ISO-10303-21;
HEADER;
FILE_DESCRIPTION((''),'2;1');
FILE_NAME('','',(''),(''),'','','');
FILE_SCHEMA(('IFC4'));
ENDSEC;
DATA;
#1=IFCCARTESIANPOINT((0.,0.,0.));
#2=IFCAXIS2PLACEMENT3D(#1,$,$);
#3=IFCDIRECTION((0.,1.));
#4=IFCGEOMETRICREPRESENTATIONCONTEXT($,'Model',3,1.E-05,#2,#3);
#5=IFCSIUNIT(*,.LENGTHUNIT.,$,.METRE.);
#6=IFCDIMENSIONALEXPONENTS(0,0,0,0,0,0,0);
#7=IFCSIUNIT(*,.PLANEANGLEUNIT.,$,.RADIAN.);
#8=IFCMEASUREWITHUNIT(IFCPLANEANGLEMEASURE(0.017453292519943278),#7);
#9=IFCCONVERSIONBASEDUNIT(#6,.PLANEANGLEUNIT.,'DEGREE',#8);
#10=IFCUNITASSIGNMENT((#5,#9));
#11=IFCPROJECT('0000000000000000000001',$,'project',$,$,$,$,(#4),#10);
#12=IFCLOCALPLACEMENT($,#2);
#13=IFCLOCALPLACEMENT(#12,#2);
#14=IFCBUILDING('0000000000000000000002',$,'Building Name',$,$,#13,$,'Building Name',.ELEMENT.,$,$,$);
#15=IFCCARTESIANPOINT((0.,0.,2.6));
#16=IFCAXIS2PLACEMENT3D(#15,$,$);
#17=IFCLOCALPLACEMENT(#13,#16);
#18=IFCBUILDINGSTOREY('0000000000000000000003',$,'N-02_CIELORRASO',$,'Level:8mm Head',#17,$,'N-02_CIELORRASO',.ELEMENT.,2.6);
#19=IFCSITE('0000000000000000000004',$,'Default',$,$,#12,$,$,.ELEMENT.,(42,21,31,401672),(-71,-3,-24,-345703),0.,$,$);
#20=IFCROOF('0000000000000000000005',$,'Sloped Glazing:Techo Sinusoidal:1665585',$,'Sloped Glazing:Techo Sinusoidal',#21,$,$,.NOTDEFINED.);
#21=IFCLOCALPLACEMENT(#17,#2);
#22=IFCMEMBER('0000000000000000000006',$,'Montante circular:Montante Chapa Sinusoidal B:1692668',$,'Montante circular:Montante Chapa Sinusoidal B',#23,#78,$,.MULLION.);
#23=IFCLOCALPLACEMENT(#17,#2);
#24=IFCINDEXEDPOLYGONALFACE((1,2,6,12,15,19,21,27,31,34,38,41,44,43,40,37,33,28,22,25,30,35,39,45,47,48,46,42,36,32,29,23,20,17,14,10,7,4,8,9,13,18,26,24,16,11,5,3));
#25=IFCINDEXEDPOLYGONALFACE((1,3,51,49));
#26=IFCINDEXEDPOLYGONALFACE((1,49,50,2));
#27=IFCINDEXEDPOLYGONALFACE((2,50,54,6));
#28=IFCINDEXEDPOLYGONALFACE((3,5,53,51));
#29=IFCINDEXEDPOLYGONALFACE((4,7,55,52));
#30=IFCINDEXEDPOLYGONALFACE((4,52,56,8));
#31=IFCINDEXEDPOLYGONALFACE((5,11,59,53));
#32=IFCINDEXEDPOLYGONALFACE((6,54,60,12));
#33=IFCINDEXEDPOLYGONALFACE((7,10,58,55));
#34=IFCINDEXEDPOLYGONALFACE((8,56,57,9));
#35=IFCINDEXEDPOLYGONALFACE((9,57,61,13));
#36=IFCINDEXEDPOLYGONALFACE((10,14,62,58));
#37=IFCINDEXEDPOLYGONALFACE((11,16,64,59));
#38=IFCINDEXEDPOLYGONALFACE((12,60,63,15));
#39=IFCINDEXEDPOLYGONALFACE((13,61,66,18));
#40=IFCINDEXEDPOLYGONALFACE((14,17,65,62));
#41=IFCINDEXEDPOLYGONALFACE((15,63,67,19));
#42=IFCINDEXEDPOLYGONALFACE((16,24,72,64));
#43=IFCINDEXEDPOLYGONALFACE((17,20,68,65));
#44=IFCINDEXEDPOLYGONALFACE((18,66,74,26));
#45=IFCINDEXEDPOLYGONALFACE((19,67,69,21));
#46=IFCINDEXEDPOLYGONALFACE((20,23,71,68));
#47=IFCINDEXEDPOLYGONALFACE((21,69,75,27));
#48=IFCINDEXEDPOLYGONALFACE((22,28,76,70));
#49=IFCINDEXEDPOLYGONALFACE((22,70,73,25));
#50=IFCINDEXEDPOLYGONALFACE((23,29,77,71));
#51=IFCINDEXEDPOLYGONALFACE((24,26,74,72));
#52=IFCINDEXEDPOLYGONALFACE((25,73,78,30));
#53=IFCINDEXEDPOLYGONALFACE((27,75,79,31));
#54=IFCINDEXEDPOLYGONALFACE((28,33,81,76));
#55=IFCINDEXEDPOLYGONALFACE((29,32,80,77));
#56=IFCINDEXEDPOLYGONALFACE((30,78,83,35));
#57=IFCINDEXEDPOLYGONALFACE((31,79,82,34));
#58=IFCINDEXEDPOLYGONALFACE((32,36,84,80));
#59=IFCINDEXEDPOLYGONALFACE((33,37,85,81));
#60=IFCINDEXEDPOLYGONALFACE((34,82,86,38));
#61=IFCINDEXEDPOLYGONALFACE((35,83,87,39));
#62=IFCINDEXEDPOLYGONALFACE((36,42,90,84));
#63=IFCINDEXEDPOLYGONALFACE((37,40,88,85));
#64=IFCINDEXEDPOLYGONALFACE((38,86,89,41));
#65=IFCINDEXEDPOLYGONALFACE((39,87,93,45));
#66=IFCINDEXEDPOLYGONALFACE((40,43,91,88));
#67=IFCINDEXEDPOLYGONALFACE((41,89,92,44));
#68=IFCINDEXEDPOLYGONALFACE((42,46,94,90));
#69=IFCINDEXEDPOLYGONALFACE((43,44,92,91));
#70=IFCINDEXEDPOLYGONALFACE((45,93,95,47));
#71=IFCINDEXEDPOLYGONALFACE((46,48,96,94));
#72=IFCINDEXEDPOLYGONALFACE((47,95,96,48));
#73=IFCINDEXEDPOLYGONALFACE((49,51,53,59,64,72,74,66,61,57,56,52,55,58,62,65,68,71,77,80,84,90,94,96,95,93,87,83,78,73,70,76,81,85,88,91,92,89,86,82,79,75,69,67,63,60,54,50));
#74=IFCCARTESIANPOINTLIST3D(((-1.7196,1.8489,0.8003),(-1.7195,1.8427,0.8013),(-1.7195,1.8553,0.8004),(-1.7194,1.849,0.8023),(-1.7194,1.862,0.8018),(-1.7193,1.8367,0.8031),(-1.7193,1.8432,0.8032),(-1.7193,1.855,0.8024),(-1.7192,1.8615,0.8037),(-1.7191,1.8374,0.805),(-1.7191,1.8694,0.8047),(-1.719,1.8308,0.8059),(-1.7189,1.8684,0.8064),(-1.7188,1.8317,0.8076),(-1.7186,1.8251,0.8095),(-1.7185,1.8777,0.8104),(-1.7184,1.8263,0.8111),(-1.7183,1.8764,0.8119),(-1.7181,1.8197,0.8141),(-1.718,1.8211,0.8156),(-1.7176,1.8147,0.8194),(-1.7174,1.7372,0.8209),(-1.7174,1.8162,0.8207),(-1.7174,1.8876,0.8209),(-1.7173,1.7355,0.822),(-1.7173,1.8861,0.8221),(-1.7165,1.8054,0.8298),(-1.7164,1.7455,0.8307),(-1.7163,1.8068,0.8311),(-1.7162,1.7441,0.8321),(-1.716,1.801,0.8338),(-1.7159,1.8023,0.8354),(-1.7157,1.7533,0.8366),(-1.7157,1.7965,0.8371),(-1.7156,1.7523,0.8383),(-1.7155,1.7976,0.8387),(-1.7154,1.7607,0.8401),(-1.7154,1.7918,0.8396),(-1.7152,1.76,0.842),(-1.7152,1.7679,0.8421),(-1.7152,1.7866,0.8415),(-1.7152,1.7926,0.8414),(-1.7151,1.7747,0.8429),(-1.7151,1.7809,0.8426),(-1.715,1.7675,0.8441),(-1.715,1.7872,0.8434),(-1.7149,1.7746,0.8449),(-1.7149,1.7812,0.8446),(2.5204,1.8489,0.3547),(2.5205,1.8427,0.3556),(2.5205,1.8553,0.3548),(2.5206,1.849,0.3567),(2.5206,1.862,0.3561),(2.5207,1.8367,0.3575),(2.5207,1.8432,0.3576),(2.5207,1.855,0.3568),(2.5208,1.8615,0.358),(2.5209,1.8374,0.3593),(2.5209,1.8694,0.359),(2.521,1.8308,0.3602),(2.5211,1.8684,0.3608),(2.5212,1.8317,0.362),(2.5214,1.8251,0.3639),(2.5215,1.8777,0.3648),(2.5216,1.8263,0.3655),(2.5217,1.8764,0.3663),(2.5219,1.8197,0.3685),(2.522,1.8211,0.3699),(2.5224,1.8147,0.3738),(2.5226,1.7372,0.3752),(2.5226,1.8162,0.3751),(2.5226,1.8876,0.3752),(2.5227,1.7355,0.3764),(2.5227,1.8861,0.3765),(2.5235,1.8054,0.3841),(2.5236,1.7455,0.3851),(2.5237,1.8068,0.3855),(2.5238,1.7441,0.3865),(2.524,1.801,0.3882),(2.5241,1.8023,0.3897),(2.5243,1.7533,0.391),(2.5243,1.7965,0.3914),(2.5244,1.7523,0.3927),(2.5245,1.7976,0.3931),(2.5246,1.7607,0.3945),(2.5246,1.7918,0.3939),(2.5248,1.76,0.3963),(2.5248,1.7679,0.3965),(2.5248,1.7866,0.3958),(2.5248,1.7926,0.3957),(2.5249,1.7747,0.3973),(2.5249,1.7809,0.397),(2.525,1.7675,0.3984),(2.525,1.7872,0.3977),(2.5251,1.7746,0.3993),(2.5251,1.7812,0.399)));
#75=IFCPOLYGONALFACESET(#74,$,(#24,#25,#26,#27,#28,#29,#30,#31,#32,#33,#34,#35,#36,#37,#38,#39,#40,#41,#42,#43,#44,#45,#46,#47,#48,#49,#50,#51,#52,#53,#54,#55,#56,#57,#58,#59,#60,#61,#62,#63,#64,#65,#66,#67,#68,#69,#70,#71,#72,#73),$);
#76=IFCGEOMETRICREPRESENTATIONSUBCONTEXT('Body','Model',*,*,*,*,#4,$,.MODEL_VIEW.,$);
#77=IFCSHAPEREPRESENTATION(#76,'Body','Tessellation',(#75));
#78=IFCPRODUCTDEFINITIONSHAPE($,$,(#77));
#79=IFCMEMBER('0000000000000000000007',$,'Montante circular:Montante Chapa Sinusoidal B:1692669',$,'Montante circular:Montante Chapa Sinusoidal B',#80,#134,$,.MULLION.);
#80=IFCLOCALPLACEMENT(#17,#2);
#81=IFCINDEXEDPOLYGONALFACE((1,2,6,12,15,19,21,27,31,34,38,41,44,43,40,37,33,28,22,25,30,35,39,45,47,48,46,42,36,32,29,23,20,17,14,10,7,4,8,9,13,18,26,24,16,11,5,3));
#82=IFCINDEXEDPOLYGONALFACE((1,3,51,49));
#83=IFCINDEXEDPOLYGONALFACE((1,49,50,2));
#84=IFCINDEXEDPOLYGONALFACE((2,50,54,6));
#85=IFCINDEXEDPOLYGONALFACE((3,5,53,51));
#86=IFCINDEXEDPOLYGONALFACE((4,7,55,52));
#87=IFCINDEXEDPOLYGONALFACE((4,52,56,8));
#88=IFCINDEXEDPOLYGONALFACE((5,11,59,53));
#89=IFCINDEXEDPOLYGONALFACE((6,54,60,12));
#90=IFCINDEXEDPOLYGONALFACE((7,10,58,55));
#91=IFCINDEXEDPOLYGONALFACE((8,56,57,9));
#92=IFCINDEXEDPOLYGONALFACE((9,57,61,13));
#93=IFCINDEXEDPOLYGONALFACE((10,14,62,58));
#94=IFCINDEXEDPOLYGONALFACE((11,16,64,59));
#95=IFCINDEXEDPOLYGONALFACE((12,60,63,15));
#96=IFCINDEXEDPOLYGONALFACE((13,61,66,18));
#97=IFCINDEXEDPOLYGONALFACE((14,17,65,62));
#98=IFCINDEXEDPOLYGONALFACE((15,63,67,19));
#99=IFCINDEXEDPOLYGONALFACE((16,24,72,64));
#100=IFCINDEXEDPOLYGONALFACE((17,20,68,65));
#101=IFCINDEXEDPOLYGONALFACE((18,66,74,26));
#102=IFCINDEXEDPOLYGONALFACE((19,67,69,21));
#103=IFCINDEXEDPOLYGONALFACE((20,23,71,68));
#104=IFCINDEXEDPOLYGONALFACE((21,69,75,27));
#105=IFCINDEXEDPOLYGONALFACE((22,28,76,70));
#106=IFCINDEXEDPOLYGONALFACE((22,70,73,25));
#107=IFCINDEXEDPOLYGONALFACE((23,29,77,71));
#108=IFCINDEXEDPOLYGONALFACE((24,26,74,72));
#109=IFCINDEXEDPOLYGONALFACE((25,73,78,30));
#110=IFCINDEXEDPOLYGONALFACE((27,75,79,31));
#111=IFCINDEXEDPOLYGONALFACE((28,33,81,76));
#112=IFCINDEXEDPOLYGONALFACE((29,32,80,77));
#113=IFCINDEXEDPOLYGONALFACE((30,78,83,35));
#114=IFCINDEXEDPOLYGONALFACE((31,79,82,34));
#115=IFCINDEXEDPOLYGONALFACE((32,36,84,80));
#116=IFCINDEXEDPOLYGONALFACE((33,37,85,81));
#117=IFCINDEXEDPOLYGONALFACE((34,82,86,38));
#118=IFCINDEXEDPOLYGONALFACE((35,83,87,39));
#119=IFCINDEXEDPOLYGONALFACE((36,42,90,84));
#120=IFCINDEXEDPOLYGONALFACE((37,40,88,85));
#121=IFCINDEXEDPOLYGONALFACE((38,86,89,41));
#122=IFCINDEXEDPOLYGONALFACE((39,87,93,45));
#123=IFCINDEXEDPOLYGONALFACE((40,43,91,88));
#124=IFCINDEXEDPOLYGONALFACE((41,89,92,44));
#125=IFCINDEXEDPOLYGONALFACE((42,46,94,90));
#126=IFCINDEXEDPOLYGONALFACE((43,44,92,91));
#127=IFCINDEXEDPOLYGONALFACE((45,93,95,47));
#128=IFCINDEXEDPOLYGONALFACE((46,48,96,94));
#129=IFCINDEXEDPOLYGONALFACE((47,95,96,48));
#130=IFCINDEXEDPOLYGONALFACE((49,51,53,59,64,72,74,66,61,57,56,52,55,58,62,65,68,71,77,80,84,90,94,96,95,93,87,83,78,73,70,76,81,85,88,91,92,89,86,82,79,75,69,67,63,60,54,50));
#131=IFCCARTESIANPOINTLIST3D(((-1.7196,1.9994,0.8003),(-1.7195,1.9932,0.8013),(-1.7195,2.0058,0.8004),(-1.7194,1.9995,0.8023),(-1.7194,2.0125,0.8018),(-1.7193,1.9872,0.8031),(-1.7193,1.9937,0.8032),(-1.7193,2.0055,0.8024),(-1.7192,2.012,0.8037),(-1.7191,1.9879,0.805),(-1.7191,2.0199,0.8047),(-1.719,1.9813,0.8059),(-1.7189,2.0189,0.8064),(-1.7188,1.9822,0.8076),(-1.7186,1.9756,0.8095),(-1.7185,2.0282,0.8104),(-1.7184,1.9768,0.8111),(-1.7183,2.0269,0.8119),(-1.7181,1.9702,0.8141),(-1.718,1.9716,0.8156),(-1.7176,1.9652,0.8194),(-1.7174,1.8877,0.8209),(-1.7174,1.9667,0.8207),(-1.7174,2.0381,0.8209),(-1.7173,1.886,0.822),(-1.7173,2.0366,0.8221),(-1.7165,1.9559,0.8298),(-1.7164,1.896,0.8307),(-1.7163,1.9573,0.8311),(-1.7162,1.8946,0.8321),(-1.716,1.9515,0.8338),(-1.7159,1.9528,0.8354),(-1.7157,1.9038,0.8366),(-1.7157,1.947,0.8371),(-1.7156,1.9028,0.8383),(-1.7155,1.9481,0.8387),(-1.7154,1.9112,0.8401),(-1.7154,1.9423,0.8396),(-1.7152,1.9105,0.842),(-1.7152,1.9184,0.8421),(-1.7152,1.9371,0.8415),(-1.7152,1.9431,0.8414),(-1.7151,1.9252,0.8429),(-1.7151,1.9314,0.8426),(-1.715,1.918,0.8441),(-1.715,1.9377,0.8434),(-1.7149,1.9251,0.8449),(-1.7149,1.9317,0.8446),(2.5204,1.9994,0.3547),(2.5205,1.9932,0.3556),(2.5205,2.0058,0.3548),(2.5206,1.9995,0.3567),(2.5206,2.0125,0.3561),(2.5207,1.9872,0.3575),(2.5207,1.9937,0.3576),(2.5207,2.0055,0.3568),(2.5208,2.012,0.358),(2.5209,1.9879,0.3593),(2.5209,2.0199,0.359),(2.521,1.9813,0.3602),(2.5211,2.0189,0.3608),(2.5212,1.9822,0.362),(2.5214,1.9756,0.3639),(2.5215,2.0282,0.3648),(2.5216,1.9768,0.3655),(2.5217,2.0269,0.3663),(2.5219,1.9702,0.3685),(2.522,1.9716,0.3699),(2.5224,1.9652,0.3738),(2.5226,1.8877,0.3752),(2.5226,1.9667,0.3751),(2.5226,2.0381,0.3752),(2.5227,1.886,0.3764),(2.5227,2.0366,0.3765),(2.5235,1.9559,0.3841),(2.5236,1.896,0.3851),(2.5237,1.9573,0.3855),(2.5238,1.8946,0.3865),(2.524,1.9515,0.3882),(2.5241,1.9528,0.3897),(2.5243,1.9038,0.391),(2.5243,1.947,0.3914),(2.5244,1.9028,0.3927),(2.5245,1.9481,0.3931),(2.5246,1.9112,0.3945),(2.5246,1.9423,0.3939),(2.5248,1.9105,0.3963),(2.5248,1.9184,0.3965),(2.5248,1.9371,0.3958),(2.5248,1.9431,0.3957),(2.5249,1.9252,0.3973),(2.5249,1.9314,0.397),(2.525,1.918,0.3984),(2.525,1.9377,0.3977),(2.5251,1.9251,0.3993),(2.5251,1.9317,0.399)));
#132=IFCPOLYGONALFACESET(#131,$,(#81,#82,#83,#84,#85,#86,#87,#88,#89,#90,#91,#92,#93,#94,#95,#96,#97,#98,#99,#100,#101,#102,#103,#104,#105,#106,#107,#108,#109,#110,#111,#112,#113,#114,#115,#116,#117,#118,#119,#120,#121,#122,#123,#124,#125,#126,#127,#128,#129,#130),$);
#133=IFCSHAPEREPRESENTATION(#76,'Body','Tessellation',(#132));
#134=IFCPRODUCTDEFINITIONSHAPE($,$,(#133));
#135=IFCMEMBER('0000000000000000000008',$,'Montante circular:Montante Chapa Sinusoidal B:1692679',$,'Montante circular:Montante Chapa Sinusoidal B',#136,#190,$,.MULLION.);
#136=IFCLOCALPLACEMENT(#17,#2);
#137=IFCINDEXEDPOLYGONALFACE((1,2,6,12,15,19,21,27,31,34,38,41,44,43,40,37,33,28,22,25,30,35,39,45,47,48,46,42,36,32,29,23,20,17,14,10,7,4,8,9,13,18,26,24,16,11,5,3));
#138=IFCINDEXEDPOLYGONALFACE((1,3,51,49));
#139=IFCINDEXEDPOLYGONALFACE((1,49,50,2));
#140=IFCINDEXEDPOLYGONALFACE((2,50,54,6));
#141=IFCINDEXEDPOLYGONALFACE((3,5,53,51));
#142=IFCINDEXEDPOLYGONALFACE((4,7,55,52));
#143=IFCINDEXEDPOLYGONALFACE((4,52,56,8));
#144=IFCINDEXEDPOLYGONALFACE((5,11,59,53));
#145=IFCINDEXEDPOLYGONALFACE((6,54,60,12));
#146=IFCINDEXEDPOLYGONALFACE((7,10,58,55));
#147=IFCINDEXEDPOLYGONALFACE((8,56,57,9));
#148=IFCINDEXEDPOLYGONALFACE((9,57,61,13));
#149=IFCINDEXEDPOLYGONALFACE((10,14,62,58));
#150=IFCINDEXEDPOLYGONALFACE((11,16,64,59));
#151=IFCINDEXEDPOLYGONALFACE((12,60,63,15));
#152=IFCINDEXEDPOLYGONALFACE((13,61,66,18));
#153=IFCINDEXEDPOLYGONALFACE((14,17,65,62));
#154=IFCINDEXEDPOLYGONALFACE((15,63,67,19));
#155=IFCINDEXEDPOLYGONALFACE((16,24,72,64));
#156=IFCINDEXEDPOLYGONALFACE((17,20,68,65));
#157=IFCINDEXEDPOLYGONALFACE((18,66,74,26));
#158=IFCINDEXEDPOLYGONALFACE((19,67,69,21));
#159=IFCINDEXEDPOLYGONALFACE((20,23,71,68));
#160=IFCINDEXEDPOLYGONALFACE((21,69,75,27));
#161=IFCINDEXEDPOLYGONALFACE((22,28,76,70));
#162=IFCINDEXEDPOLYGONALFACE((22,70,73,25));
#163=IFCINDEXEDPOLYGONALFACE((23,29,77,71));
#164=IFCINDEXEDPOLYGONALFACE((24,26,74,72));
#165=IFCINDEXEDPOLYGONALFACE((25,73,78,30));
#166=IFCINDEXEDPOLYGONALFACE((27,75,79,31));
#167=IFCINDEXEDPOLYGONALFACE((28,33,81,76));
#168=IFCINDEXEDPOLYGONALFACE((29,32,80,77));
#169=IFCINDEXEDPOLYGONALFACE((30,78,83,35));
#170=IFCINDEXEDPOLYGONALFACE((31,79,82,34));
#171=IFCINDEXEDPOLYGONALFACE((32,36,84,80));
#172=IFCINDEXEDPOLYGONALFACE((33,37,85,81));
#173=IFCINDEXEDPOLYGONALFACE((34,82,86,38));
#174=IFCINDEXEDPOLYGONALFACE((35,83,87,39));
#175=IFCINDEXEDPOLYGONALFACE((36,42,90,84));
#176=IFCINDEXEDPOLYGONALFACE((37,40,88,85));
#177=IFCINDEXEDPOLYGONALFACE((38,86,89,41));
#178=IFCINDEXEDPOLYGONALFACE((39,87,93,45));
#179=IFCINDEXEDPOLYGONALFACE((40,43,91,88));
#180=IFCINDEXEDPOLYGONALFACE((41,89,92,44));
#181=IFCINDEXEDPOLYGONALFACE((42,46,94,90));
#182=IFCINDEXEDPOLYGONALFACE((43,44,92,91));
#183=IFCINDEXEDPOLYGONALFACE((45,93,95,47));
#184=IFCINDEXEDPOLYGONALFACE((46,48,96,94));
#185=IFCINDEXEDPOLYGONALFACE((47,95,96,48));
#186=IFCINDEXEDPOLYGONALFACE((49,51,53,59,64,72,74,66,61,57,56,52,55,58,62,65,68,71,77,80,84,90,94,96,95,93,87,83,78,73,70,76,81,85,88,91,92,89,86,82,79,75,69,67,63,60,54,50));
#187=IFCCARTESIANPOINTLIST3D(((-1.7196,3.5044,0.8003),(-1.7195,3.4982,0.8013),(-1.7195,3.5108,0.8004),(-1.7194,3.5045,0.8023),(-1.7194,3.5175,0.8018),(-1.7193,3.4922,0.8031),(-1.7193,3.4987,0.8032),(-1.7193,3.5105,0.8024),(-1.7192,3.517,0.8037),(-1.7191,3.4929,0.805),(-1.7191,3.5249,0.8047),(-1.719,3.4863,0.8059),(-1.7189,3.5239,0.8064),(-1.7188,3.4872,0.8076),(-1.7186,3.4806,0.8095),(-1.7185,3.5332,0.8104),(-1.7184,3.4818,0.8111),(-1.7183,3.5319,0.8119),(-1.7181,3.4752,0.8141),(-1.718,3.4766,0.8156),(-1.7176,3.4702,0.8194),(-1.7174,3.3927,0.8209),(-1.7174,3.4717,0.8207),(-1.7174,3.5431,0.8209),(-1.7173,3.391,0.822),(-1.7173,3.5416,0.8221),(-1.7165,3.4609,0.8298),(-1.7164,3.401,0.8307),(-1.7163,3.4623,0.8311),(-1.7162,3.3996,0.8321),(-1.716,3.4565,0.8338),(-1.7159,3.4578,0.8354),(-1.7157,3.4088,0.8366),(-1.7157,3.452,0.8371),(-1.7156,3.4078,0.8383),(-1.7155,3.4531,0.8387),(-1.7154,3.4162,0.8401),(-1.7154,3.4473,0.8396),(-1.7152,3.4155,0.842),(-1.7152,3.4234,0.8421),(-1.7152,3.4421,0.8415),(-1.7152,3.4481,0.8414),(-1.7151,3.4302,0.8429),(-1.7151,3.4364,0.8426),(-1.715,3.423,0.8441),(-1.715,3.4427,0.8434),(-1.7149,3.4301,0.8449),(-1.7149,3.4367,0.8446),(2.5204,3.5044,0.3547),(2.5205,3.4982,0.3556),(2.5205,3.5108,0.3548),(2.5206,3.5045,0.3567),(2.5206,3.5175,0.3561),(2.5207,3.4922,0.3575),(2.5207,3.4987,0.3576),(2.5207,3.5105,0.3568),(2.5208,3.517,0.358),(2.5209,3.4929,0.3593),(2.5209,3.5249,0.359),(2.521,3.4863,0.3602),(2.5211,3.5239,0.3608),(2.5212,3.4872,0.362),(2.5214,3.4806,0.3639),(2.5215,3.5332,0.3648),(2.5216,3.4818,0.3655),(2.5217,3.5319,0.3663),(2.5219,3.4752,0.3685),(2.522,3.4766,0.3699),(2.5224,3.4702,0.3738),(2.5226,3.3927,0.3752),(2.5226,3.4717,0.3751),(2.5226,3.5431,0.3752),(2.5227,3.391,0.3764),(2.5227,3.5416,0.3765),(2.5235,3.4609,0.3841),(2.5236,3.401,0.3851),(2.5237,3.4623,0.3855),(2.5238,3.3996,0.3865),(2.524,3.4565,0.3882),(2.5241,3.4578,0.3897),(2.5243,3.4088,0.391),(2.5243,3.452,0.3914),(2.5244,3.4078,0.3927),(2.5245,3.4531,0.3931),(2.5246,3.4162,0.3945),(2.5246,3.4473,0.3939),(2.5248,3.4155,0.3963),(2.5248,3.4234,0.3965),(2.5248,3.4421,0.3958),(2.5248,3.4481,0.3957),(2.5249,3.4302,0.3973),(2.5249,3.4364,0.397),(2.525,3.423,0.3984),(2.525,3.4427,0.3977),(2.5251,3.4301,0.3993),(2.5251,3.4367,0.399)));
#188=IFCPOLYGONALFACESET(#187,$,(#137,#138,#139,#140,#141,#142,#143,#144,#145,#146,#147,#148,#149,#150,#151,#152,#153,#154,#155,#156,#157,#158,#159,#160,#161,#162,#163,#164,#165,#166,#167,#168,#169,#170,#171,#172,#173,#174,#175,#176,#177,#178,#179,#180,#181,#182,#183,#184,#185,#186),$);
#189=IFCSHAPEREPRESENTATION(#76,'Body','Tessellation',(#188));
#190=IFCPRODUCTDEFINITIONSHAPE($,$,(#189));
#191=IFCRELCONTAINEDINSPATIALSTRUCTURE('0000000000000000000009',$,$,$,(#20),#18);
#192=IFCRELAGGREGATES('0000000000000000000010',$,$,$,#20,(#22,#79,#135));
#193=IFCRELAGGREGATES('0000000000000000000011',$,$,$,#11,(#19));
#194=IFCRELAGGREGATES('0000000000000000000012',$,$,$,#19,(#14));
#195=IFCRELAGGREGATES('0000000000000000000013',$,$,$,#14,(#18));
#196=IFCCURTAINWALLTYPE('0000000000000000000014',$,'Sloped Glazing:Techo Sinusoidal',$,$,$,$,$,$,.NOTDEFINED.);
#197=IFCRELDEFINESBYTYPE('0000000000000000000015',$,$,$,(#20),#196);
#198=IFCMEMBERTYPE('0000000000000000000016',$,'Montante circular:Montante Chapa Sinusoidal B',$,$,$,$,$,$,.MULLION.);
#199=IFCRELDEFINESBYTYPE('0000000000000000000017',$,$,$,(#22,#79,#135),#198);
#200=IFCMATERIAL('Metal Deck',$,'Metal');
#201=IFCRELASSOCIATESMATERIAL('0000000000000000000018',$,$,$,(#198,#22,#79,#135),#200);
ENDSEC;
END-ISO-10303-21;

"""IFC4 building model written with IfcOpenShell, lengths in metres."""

from ifc_helpers import new_model, entity, si_unit, converted_unit, direction, frame, origin, place, context, subcontext, project, spatial, indexed_curve, outline, extrude, source, transform, mapped, material, type_object, type_shapes, element, aggregate, save


model = new_model("IFC4")

# Units and contexts
model_context = context("Model", 3, precision=1e-05, world=origin(), true_north=direction((0.0, 1.0)))
body_context = subcontext(model_context, "Body", "Model", "MODEL_VIEW")
ifc_project = project(units=[si_unit("LENGTHUNIT", "METRE"), converted_unit("PLANEANGLEUNIT", "DEGREE", entity("IfcPlaneAngleMeasure", 0.017453292519943278), si_unit("PLANEANGLEUNIT", "RADIAN"), dimensions=[0, 0, 0, 0, 0, 0, 0])], contexts=[model_context])

# Site, building, storey
site_placement = place(None, origin())
site = spatial("IfcSite", under=ifc_project, at=site_placement, Name="Default", CompositionType="ELEMENT", RefLatitude=(42, 21, 31, 401672), RefLongitude=(-71, -3, -24, -345703), RefElevation=0.0)
building_placement = place(site_placement, origin())
building = spatial("IfcBuilding", under=site, at=building_placement, Name="Building Name", LongName="Building Name", CompositionType="ELEMENT")
storey_placement = place(building_placement, frame((0.0, 0.0, 2.6)))
storey = spatial("IfcBuildingStorey", under=building, at=storey_placement, Name="N-02_CIELORRASO", ObjectType="Level:8mm Head", LongName="N-02_CIELORRASO", CompositionType="ELEMENT", Elevation=2.6)

# Roof, members
curtain_wall_type = type_object("IfcCurtainWallType", Name="Sloped Glazing:Techo Sinusoidal", PredefinedType="NOTDEFINED")
roof_placement = place(storey_placement, frame((0.0, 0.0, -2.6)))
roof = element("IfcRoof", 1, at=roof_placement, inside=storey, type_object=curtain_wall_type, Name="Sloped Glazing:Techo Sinusoidal:1665585", ObjectType="Sloped Glazing:Techo Sinusoidal", PredefinedType="NOTDEFINED")
ifc_material = material(Name="Metal Deck", Category="Metal")
member_type = type_object("IfcMemberType", Name="Montante circular:Montante Chapa Sinusoidal B", PredefinedType="MULLION", material=ifc_material)
shared_shape = source(origin(), body_context, "Body", "SweptSolid", [
    extrude(outline(indexed_curve([(0.0595, -0.0443), (0.0615, -0.0443), (0.0603, -0.031), (0.0572, -0.0213), (0.053, -0.0138), (0.0481, -0.0078), (0.0427, -0.003), (0.0372, 0.0005), (0.0315, 0.0029), (0.0259, 0.0044), (0.0203, 0.0051), (0.0146, 0.005), (0.0084, 0.0041), (-0.0053, 0.0009), (-0.0123, -0.0005), (-0.0191, -0.0012), (-0.0256, -0.001), (-0.0317, 0.0001), (-0.0375, 0.0019), (-0.0428, 0.0046), (-0.0477, 0.0081), (-0.0522, 0.0128), (-0.0563, 0.0191), (-0.0597, 0.0282), (-0.0617, 0.0421), (-0.0637, 0.042), (-0.0616, 0.0277), (-0.0581, 0.0182), (-0.0537, 0.0116), (-0.049, 0.0066), (-0.0438, 0.0028), (-0.0382, 0.0001), (-0.0322, -0.0019), (-0.0258, -0.003), (-0.019, -0.0032), (-0.012, -0.0025), (-0.0048, -0.0011), (0.0088, 0.0021), (0.0147, 0.003), (0.0202, 0.0031), (0.0255, 0.0024), (0.0309, 0.001), (0.0362, -0.0013), (0.0415, -0.0046), (0.0466, -0.0092), (0.0513, -0.0149), (0.0554, -0.0221), (0.0584, -0.0314), (0.0595, -0.0443)], self_intersect=False)), frame((-0.007, 0.0228, -4.2634), z_axis=(0.0, 0.0, 1.0), x_axis=(-0.819152, -0.573576, 0.0)), (0.0, 0.0, 1.0), 4.2634),
])
type_shapes(member_type, [shared_shape])
member_1_placement = place(roof_placement, frame((-1.7148, 1.8184, 3.4456), z_axis=(-0.994522, 0.0, 0.104528), x_axis=(0.0, 1.0, 0.0)))
member_1 = element("IfcMember", 2, at=member_1_placement, type_object=member_type, material=ifc_material, Name="Montante circular:Montante Chapa Sinusoidal B:1692668", ObjectType="Montante circular:Montante Chapa Sinusoidal B", PredefinedType="MULLION", context=body_context, shape_type="MappedRepresentation", body=[
    mapped(shared_shape, transform((0.0, 0.0, 0.0), scale=1.0)),
])
member_2_placement = place(roof_placement, frame((-1.7148, 1.9689, 3.4456), z_axis=(-0.994522, 0.0, 0.104528), x_axis=(0.0, 1.0, 0.0)))
member_2 = element("IfcMember", 3, at=member_2_placement, type_object=member_type, material=ifc_material, Name="Montante circular:Montante Chapa Sinusoidal B:1692669", ObjectType="Montante circular:Montante Chapa Sinusoidal B", PredefinedType="MULLION", context=body_context, shape_type="MappedRepresentation", body=[
    mapped(shared_shape, transform((0.0, 0.0, 0.0), scale=1.0)),
])
member_3_placement = place(roof_placement, frame((-1.7148, 3.4739, 3.4456), z_axis=(-0.994522, 0.0, 0.104528), x_axis=(0.0, 1.0, 0.0)))
member_3 = element("IfcMember", 4, at=member_3_placement, type_object=member_type, material=ifc_material, Name="Montante circular:Montante Chapa Sinusoidal B:1692679", ObjectType="Montante circular:Montante Chapa Sinusoidal B", PredefinedType="MULLION", context=body_context, shape_type="MappedRepresentation", body=[
    mapped(shared_shape, transform((0.0, 0.0, 0.0), scale=1.0)),
])
aggregate(roof, [member_1, member_2, member_3])

save(model, "model.ifc")
